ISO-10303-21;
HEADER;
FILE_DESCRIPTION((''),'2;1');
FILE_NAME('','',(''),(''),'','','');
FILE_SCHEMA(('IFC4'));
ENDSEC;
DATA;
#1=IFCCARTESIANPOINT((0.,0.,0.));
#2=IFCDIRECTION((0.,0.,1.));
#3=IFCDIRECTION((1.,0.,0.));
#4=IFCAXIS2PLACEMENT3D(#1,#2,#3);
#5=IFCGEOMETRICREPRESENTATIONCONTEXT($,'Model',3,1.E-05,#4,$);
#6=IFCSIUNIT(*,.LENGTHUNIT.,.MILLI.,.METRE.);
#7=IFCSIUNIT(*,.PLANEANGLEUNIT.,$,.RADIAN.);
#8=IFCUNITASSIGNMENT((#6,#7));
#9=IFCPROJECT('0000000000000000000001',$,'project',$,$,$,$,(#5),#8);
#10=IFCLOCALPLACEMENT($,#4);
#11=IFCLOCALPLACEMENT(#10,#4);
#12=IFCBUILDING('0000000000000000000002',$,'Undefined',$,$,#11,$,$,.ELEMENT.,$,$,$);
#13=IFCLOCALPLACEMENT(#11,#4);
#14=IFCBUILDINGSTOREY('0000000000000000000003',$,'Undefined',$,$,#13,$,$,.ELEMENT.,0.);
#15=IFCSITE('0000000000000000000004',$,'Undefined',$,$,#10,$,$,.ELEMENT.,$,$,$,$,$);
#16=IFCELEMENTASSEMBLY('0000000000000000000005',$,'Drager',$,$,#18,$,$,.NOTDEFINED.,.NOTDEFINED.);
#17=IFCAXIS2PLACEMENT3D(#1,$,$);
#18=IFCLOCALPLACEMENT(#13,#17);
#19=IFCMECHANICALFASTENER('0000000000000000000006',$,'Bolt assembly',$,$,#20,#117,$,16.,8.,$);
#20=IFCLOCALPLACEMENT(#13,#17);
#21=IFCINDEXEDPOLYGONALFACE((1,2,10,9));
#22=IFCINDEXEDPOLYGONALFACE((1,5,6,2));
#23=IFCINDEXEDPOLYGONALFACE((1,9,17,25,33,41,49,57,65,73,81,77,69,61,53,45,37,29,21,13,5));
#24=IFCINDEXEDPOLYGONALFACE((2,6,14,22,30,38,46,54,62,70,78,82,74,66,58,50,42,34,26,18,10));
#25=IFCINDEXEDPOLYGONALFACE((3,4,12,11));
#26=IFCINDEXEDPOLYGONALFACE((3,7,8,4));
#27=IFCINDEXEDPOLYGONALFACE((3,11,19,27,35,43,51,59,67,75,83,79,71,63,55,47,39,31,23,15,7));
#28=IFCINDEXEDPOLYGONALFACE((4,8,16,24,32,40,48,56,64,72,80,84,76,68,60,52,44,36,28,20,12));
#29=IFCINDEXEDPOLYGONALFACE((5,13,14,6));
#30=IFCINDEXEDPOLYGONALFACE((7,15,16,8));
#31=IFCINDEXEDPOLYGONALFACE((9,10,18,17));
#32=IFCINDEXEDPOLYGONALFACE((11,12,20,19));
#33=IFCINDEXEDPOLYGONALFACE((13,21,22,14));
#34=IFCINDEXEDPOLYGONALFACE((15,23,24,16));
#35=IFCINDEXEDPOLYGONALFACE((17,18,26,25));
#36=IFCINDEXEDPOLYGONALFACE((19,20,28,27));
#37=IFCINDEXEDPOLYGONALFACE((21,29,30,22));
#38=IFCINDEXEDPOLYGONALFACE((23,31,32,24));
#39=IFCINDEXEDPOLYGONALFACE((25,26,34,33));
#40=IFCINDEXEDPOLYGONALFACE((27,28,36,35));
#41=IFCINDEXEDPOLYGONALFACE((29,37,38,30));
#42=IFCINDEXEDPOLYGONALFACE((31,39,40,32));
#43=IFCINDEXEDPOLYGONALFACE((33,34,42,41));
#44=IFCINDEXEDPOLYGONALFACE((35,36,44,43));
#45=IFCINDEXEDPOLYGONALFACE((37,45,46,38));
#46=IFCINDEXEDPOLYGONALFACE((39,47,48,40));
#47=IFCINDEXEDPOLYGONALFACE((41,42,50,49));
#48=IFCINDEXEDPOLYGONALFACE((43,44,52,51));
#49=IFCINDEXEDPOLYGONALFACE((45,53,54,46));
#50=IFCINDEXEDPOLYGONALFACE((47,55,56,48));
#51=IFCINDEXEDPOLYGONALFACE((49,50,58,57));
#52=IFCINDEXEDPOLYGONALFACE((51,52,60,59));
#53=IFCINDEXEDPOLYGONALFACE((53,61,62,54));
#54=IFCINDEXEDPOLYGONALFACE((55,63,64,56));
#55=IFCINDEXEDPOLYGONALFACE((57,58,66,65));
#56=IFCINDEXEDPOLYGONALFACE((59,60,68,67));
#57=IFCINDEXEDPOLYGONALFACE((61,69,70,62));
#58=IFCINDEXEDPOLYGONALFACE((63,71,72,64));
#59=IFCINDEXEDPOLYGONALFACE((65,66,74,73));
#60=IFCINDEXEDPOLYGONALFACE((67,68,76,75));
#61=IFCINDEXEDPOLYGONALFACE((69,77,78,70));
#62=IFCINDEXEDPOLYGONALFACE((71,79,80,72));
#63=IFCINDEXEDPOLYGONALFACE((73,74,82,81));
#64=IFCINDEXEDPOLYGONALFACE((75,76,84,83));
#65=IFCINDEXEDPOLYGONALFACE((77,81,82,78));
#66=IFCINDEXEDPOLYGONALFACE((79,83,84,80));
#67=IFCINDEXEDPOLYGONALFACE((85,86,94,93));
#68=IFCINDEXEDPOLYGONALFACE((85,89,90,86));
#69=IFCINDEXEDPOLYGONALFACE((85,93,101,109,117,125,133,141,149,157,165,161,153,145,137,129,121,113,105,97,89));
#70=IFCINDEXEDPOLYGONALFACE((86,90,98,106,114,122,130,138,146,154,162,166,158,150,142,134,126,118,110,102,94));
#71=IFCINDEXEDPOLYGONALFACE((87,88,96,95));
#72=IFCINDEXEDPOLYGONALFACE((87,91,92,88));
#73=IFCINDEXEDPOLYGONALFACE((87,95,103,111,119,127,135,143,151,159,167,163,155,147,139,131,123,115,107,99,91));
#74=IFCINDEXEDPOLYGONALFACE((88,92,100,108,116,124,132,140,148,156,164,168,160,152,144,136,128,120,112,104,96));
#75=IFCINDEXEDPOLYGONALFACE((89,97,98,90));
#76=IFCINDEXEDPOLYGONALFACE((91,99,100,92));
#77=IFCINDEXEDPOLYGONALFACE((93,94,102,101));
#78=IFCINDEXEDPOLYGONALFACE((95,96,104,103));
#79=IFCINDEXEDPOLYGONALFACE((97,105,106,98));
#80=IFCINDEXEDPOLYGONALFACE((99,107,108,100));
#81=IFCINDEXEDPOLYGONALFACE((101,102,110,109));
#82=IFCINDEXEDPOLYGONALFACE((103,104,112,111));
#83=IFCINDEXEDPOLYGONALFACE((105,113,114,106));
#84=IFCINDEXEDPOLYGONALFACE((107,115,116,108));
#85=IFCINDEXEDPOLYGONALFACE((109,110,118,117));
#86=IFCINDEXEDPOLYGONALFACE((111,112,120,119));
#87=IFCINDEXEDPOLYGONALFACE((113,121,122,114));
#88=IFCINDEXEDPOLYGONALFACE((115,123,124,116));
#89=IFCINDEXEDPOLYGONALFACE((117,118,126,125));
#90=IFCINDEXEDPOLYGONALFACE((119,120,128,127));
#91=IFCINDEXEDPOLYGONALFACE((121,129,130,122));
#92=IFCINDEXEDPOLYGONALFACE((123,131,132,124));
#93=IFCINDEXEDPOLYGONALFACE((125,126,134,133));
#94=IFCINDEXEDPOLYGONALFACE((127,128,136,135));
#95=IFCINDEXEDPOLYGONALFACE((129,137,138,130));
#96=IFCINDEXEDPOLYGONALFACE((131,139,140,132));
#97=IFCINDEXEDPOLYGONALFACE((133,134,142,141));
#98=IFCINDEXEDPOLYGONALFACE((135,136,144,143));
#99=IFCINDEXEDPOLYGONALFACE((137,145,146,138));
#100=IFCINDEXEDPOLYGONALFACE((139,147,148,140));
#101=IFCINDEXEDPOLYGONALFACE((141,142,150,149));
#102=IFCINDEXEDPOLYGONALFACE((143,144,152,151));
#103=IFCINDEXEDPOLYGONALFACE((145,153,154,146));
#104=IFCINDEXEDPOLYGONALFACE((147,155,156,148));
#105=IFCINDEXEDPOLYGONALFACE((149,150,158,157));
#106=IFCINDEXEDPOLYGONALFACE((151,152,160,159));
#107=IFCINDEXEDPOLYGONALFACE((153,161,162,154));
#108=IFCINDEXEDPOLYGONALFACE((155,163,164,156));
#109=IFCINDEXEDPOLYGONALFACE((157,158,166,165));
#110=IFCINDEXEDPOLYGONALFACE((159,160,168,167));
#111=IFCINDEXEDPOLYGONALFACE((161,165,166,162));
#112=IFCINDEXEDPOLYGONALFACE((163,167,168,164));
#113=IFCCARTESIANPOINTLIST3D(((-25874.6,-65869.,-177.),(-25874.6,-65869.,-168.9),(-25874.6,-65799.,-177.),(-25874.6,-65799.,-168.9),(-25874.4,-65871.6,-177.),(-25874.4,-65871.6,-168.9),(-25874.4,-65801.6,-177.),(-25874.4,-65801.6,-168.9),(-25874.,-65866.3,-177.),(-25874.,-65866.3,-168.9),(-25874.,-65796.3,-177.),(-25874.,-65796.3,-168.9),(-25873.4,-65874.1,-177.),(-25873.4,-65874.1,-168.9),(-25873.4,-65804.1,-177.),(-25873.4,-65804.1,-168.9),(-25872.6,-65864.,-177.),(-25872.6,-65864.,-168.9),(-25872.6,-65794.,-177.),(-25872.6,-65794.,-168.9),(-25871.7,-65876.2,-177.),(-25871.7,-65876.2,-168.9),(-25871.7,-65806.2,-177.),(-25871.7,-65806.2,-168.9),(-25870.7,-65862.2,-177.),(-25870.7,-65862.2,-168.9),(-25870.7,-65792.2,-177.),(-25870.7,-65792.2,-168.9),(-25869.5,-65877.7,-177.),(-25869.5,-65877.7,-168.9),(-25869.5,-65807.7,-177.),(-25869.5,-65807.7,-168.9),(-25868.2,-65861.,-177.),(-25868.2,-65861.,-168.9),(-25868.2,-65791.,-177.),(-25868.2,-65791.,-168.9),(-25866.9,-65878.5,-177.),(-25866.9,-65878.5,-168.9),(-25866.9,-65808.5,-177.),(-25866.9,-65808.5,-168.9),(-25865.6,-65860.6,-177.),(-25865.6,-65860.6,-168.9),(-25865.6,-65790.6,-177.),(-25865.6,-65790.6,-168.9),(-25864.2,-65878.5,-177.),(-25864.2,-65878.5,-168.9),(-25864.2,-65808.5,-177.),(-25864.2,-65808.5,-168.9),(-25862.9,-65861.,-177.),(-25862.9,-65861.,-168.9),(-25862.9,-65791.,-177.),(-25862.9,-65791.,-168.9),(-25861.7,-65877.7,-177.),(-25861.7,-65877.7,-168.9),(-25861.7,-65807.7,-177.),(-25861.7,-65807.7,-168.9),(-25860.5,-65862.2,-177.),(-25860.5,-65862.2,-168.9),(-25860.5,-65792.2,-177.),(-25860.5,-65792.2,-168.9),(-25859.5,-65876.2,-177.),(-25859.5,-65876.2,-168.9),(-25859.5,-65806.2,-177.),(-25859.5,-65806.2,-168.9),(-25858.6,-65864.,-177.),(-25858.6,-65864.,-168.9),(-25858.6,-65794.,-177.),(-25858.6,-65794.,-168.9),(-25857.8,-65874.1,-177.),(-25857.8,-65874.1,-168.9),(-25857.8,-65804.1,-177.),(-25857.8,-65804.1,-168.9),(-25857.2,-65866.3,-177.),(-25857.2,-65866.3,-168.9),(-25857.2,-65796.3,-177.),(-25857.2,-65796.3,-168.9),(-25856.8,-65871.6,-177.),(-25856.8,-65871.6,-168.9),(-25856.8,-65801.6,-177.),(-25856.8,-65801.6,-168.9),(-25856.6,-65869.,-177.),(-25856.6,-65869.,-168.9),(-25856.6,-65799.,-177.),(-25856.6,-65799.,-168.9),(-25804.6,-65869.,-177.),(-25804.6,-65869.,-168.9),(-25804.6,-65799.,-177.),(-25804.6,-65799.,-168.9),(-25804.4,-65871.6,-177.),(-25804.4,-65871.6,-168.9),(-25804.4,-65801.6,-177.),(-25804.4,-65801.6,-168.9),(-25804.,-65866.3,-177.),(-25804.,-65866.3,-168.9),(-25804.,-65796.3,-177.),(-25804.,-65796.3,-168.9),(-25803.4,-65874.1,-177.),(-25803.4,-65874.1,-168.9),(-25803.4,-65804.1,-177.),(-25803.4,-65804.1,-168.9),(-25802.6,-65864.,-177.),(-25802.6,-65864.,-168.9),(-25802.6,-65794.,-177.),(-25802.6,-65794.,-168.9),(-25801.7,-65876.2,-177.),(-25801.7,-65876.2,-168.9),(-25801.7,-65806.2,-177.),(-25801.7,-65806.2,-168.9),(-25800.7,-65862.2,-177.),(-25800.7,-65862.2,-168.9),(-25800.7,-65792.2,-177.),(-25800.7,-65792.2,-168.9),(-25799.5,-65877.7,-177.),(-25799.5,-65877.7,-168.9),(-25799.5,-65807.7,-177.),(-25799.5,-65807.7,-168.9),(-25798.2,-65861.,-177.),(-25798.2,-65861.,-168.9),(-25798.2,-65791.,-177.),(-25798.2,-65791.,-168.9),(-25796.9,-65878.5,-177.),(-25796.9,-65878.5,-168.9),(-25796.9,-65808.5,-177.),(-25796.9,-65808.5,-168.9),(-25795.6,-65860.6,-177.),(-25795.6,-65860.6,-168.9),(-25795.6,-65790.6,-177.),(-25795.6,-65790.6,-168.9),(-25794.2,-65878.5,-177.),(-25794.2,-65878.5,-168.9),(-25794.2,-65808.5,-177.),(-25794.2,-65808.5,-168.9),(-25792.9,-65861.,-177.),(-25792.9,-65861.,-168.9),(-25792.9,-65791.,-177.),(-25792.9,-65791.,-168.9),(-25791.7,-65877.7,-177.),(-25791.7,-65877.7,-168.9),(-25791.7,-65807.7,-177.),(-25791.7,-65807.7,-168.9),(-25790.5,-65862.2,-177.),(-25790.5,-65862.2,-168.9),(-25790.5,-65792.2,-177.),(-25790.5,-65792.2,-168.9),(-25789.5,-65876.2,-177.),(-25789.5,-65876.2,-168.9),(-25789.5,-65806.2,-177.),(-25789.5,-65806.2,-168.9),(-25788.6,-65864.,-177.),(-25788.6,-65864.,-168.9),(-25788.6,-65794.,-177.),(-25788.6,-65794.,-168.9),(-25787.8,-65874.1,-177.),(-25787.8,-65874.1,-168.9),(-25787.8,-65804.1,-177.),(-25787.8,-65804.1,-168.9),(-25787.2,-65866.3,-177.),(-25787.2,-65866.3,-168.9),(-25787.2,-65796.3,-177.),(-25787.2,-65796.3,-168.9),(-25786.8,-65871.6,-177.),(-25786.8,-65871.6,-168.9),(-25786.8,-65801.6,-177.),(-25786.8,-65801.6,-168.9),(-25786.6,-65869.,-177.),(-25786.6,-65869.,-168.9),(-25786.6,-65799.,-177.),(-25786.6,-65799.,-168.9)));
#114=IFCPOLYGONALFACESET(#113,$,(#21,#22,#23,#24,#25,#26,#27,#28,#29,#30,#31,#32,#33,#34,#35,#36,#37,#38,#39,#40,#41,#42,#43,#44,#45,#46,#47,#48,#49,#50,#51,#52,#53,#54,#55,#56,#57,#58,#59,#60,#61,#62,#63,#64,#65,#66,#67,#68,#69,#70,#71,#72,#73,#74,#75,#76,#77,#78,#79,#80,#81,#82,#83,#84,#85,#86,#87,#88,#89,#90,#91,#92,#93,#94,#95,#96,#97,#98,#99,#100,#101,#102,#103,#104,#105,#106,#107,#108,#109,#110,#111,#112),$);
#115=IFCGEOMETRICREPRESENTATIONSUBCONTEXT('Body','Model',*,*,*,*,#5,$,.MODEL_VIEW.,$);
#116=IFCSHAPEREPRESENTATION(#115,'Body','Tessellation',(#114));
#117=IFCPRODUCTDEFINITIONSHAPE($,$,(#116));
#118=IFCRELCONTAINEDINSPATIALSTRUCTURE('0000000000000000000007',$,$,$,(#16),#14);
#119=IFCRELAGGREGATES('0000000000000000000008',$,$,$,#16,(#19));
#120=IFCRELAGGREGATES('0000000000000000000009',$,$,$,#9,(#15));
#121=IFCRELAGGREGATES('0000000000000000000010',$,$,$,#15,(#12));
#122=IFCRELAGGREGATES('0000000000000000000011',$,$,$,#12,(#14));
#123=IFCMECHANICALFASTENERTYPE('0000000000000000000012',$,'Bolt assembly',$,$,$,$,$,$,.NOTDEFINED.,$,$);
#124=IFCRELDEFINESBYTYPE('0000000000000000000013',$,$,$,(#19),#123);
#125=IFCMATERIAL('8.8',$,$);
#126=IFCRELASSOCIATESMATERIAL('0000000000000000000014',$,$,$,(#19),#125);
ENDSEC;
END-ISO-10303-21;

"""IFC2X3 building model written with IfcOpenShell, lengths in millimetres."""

from ifc_helpers import new_model, si_unit, frame, origin_with_axes, origin_2d_with_axis, place, context, subcontext, project, spatial, circle, extrude, source, transform, mapped, material, type_object, element, aggregate, save


model = new_model("IFC2X3")

# Units and contexts
model_context = context("Model", 3, precision=1e-05, world=origin_with_axes())
body_context = subcontext(model_context, "Body", "Model", "MODEL_VIEW")
ifc_project = project(units=[si_unit("LENGTHUNIT", "METRE", prefix="MILLI"), si_unit("PLANEANGLEUNIT", "RADIAN")], contexts=[model_context])

# Site, building, storey
site_placement = place(None, origin_with_axes())
site = spatial("IfcSite", under=ifc_project, at=site_placement, Name="Undefined", CompositionType="ELEMENT")
building_placement = place(site_placement, origin_with_axes())
building = spatial("IfcBuilding", under=site, at=building_placement, Name="Undefined", CompositionType="ELEMENT")
storey_placement = place(building_placement, origin_with_axes())
storey = spatial("IfcBuildingStorey", under=building, at=storey_placement, Name="Undefined", CompositionType="ELEMENT", Elevation=0.0)

# Element assembly
assembly_1_placement = place(storey_placement, origin_with_axes())
assembly_1 = element("IfcElementAssembly", 1, at=assembly_1_placement, inside=storey, Name="Drager", AssemblyPlace="NOTDEFINED", PredefinedType="NOTDEFINED")

# Mechanical fastener
ifc_material_1 = material(Name="8.8")
mechanical_fastener_type = type_object("IfcMechanicalFastenerType", Name="Bolt assembly")
shared_shape_1 = source(origin_with_axes(), body_context, "Body", "SweptSolid", [
    extrude(circle(Radius=9.0, at=origin_2d_with_axis()), frame((0.0, 0.0, 0.0), z_axis=(0.0, 1.0, 0.0), x_axis=(1.0, 0.0, 0.0)), (0.0, 0.0, 1.0), 8.1),
])
mechanical_fastener_1_placement = place(assembly_1_placement, frame((-25830.6, -65869.6, -177.0), z_axis=(1.0, 0.0, 0.0), x_axis=(0.0, 1.0, 0.0)))
mechanical_fastener_1 = element("IfcMechanicalFastener", 2, at=mechanical_fastener_1_placement, type_object=mechanical_fastener_type, material=ifc_material_1, Name="Bolt assembly", NominalDiameter=16.0, NominalLength=8.0, context=body_context, shape_type="MappedRepresentation", body=[
    mapped(shared_shape_1, transform((0.0, 0.0, -35.0))),
    mapped(shared_shape_1, transform((70.0, 0.0, -35.0))),
    mapped(shared_shape_1, transform((0.0, 0.0, 35.0))),
    mapped(shared_shape_1, transform((70.0, 0.0, 35.0))),
])
aggregate(assembly_1, [mechanical_fastener_1])

save(model, "model.ifc")
